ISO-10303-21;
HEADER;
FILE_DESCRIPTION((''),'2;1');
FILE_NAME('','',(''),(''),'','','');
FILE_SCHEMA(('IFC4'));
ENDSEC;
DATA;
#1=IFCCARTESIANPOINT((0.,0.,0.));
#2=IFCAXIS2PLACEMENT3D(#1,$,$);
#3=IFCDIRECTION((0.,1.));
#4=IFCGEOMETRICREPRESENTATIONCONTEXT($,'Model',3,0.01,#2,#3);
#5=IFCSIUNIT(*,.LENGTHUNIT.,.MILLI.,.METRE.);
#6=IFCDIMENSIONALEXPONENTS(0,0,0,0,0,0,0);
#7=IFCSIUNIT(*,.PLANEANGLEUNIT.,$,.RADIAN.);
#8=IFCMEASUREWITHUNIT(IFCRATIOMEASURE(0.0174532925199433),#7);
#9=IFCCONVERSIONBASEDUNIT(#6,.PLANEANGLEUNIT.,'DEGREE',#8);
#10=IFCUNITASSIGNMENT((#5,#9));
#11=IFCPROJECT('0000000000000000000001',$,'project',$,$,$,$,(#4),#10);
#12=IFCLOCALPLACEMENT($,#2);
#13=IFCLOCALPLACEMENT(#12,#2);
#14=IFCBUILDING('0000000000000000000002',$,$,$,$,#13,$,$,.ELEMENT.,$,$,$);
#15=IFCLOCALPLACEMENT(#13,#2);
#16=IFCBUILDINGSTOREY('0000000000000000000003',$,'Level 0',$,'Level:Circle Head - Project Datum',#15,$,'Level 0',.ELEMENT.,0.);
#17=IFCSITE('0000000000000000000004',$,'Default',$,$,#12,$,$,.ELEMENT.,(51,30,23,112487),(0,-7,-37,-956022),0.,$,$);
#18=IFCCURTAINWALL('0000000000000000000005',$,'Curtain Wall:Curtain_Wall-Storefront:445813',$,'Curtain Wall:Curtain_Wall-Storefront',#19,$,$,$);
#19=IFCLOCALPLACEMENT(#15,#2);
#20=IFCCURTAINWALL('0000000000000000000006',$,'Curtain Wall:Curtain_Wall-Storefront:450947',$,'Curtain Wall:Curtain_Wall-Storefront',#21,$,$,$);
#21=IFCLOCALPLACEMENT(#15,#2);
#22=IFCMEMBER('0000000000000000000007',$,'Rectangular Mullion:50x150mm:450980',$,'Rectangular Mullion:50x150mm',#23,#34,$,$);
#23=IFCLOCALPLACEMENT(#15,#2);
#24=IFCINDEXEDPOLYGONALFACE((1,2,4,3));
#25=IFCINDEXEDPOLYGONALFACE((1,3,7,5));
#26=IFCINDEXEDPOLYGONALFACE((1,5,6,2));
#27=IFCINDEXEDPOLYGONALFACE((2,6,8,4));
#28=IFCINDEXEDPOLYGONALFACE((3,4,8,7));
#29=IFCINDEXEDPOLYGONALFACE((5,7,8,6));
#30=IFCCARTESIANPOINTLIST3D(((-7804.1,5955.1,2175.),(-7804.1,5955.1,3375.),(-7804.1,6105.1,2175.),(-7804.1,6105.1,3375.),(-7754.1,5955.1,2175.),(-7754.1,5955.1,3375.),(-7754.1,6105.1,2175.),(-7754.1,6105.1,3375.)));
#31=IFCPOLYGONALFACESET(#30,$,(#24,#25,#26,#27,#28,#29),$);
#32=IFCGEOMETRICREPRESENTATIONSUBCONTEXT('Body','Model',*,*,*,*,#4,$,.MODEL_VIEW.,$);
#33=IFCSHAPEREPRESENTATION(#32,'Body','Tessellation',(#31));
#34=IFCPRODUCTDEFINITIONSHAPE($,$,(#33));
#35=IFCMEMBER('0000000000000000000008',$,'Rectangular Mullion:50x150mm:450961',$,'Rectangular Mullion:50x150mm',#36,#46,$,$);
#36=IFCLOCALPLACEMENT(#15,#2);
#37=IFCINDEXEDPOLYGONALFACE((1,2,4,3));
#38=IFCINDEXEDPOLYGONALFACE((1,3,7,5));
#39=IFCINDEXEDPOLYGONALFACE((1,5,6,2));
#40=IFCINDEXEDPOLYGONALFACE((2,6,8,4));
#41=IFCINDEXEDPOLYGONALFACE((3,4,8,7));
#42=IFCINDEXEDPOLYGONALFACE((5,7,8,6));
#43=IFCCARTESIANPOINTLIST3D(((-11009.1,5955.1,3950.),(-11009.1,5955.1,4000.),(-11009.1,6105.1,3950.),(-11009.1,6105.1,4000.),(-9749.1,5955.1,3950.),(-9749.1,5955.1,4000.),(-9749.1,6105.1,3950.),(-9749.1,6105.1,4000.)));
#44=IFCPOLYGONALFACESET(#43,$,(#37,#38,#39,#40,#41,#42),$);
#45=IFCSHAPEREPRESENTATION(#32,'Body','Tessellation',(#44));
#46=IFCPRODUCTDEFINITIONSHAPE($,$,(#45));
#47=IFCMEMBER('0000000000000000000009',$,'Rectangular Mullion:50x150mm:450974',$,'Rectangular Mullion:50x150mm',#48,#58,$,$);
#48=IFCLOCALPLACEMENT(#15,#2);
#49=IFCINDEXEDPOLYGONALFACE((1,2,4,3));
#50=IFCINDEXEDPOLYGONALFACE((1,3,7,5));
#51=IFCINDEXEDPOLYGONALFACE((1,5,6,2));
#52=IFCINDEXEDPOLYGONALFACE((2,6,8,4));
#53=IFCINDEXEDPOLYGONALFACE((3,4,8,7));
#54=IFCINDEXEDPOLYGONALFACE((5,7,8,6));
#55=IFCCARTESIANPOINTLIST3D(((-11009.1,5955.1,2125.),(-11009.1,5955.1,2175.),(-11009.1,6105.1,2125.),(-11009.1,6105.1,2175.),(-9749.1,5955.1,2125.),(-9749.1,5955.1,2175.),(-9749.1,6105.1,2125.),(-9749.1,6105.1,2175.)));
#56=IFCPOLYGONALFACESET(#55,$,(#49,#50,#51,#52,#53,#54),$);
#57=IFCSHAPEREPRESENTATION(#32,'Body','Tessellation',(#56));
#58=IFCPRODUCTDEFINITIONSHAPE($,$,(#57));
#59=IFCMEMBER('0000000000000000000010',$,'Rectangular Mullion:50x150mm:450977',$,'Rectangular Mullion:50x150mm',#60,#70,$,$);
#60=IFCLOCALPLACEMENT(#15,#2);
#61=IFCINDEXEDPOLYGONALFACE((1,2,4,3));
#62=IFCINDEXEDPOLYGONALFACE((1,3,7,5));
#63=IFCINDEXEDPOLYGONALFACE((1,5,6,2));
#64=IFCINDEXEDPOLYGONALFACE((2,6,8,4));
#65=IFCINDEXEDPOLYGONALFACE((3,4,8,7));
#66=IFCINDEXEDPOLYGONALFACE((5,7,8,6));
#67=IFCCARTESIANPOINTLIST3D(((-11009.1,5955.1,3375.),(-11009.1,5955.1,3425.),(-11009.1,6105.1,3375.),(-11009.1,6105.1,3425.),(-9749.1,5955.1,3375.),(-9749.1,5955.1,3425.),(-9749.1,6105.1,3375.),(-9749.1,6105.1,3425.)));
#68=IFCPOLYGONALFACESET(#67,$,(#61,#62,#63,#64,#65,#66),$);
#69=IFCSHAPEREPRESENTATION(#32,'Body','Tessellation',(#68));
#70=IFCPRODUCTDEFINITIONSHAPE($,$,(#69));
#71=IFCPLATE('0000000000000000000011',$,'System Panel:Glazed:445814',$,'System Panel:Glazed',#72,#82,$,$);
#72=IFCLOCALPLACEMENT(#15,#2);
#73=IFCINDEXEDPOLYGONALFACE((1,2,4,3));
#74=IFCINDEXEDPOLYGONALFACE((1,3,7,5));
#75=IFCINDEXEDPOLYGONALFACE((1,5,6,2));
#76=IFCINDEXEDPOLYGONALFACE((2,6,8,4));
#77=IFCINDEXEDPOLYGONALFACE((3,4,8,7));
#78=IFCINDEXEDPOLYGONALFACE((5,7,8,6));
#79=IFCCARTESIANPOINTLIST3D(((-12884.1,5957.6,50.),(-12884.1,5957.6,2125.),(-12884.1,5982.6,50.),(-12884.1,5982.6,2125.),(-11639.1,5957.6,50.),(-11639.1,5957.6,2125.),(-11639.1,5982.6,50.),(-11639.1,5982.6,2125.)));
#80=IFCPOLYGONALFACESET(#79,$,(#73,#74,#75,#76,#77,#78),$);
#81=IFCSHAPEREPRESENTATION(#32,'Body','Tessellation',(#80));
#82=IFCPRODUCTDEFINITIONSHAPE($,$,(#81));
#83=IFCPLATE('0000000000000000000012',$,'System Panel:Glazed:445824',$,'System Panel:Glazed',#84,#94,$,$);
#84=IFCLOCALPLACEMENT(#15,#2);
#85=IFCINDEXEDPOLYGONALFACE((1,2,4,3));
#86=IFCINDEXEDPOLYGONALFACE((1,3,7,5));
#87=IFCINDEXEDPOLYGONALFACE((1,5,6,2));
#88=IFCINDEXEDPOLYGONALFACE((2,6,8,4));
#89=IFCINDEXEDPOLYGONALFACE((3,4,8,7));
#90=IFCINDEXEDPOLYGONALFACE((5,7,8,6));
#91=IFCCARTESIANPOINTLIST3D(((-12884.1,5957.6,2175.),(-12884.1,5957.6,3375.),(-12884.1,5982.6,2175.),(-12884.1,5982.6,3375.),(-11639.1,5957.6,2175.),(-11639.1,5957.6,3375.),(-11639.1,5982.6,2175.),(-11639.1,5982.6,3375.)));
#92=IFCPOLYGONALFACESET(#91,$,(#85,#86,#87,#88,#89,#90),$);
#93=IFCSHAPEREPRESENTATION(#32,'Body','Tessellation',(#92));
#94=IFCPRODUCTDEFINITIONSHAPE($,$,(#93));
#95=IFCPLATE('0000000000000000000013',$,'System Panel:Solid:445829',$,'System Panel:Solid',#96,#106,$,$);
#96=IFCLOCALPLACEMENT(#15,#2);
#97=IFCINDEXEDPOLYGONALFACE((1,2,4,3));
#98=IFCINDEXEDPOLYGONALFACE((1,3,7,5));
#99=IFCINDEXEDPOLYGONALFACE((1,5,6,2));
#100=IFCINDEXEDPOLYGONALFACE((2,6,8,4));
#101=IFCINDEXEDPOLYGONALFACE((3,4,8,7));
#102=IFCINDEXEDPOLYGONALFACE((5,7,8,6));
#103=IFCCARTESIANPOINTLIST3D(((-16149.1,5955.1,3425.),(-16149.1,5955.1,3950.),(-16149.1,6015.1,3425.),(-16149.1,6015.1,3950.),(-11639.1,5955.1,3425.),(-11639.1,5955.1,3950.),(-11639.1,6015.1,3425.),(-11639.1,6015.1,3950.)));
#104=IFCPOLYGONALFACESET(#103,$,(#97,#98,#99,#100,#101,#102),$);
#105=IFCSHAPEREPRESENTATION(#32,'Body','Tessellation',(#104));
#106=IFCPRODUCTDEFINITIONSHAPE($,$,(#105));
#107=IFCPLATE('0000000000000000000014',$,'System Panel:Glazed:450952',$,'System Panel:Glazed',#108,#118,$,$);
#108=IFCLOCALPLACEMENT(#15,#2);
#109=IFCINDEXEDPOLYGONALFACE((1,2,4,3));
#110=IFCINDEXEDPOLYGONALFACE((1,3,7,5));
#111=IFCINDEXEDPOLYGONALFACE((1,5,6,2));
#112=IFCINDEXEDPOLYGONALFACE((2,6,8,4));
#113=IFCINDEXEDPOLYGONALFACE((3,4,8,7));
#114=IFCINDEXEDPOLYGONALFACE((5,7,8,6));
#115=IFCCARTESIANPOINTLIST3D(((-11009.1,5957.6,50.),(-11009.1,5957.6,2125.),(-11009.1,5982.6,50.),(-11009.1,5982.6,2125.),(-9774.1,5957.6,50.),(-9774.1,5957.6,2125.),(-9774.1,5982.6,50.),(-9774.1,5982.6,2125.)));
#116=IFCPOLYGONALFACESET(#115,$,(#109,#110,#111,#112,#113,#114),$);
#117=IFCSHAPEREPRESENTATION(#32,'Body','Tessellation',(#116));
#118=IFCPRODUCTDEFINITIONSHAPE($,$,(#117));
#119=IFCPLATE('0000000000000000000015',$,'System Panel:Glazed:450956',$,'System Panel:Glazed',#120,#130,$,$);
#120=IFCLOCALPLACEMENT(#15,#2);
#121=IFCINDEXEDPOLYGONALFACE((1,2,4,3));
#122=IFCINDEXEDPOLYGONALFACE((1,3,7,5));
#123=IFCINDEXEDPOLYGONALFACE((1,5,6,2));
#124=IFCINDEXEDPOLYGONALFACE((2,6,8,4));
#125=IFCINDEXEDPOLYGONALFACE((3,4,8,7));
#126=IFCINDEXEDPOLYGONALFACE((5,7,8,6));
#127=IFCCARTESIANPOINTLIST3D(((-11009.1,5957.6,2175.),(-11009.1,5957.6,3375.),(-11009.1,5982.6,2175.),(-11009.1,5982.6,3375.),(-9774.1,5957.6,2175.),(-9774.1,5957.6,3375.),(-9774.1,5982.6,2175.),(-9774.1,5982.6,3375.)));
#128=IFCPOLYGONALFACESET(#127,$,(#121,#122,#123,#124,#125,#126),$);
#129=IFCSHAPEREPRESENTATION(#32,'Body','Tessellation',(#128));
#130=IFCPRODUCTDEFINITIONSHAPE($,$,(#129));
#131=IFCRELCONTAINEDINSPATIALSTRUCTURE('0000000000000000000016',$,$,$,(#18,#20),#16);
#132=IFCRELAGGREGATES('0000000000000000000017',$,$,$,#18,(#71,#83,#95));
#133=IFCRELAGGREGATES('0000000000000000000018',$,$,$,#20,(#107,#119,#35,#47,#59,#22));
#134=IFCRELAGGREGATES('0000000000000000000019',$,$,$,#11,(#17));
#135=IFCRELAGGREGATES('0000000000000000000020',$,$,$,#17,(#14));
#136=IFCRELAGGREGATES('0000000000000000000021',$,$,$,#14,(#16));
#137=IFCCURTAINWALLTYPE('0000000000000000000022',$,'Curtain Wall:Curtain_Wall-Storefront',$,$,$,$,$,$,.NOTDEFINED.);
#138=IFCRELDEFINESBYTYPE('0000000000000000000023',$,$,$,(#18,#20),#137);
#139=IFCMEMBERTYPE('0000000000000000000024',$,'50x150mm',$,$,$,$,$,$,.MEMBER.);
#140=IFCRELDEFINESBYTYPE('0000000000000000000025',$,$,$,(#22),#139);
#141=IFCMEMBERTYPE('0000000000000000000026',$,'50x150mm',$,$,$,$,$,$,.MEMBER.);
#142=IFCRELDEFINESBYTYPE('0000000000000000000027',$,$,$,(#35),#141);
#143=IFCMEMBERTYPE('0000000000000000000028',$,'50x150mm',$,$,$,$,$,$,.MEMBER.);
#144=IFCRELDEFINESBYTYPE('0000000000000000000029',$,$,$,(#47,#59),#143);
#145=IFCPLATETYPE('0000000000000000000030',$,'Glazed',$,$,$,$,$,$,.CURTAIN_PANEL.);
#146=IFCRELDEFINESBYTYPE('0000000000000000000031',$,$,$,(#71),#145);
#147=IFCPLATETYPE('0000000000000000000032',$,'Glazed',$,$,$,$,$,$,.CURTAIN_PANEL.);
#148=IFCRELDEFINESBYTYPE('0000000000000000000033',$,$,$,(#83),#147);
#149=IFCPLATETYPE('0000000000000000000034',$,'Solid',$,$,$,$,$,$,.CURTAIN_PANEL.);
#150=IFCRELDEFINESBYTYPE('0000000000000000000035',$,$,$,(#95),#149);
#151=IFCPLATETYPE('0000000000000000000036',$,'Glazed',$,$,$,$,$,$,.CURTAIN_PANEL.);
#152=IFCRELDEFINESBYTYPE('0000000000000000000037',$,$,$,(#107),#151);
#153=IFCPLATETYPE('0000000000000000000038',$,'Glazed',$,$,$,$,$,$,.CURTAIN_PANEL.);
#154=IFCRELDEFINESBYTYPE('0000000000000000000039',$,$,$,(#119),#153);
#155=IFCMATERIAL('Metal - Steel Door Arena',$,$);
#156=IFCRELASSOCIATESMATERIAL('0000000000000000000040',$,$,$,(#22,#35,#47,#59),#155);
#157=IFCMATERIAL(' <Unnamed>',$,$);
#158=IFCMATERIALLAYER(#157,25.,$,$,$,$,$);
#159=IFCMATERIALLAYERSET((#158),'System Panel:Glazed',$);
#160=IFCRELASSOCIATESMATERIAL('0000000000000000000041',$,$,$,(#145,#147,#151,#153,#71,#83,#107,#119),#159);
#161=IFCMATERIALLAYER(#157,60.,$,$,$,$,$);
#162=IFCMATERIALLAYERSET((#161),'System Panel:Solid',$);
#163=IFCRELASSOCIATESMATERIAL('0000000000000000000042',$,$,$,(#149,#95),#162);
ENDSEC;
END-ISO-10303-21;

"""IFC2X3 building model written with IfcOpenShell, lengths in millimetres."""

from ifc_helpers import new_model, entity, si_unit, converted_unit, direction, frame, frame_2d, origin, origin_2d_with_axis, place, context, subcontext, project, spatial, rectangle, extrude, source, transform, mapped, material, layer, layer_set, layer_usage, type_object, type_shapes, element, aggregate, save


model = new_model("IFC2X3")

# Units and contexts
model_context = context("Model", 3, precision=0.01, world=origin(), true_north=direction((0.0, 1.0)))
body_context = subcontext(model_context, "Body", "Model", "MODEL_VIEW")
ifc_project = project(units=[si_unit("LENGTHUNIT", "METRE", prefix="MILLI"), converted_unit("PLANEANGLEUNIT", "DEGREE", entity("IfcRatioMeasure", 0.0174532925199433), si_unit("PLANEANGLEUNIT", "RADIAN"), dimensions=[0, 0, 0, 0, 0, 0, 0])], contexts=[model_context])

# Site, building, storey
site_placement = place(None, origin())
site = spatial("IfcSite", under=ifc_project, at=site_placement, Name="Default", CompositionType="ELEMENT", RefLatitude=(51, 30, 23, 112487), RefLongitude=(0, -7, -37, -956022), RefElevation=0.0)
building_placement = place(site_placement, origin())
building = spatial("IfcBuilding", under=site, at=building_placement, CompositionType="ELEMENT")
storey_placement = place(building_placement, origin())
storey = spatial("IfcBuildingStorey", under=building, at=storey_placement, Name="Level 0", ObjectType="Level:Circle Head - Project Datum", LongName="Level 0", CompositionType="ELEMENT", Elevation=0.0)

# Curtain walls
curtain_wall_type = type_object("IfcCurtainWallType", Name="Curtain Wall:Curtain_Wall-Storefront", PredefinedType="NOTDEFINED")
curtain_wall_1_placement = place(storey_placement, origin())
curtain_wall_1 = element("IfcCurtainWall", 1, at=curtain_wall_1_placement, inside=storey, type_object=curtain_wall_type, Name="Curtain Wall:Curtain_Wall-Storefront:445813", ObjectType="Curtain Wall:Curtain_Wall-Storefront")
ifc_material_1 = material(Name="Metal - Steel Door Arena")
curtain_wall_2_placement = place(storey_placement, origin())
curtain_wall_2 = element("IfcCurtainWall", 2, at=curtain_wall_2_placement, inside=storey, type_object=curtain_wall_type, Name="Curtain Wall:Curtain_Wall-Storefront:450947", ObjectType="Curtain Wall:Curtain_Wall-Storefront")

# Members
member_type_1 = type_object("IfcMemberType", Name="50x150mm", PredefinedType="MEMBER")
shared_shape_1 = source(origin(), body_context, "Body", "SweptSolid", [
    extrude(rectangle(XDim=150.0, YDim=50.0, at=origin_2d_with_axis()), frame((0.0, 0.0, -1200.0), z_axis=(0.0, 0.0, 1.0), x_axis=(0.0, -1.0, 0.0)), (0.0, 0.0, 1.0), 1200.0),
])
type_shapes(member_type_1, [shared_shape_1])
member_1_placement = place(storey_placement, frame((-7779.1, 6030.1, 2175.0), z_axis=(0.0, 0.0, -1.0), x_axis=(-1.0, 0.0, 0.0)))
member_1 = element("IfcMember", 3, at=member_1_placement, type_object=member_type_1, material=ifc_material_1, Name="Rectangular Mullion:50x150mm:450980", ObjectType="Rectangular Mullion:50x150mm", context=body_context, shape_type="MappedRepresentation", body=[
    mapped(shared_shape_1, transform((0.0, 0.0, 0.0), scale=1.0)),
])
member_type_2 = type_object("IfcMemberType", Name="50x150mm", PredefinedType="MEMBER")
shared_shape_2 = source(origin(), body_context, "Body", "SweptSolid", [
    extrude(rectangle(XDim=150.0, YDim=50.0, at=origin_2d_with_axis()), frame((-25.0, 0.0, -1260.0), z_axis=(0.0, 0.0, 1.0), x_axis=(0.0, -1.0, 0.0)), (0.0, 0.0, 1.0), 1260.0),
])
type_shapes(member_type_2, [shared_shape_2])
member_2_placement = place(storey_placement, frame((-11009.1, 6030.1, 4000.0), z_axis=(-1.0, 0.0, 0.0), x_axis=(0.0, 0.0, 1.0)))
member_2 = element("IfcMember", 4, at=member_2_placement, type_object=member_type_2, material=ifc_material_1, Name="Rectangular Mullion:50x150mm:450961", ObjectType="Rectangular Mullion:50x150mm", context=body_context, shape_type="MappedRepresentation", body=[
    mapped(shared_shape_2, transform((0.0, 0.0, 0.0), scale=1.0)),
])
member_type_3 = type_object("IfcMemberType", Name="50x150mm", PredefinedType="MEMBER")
shared_shape_3 = source(origin(), body_context, "Body", "SweptSolid", [
    extrude(rectangle(XDim=150.0, YDim=50.0, at=origin_2d_with_axis()), frame((0.0, 0.0, -1260.0), z_axis=(0.0, 0.0, 1.0), x_axis=(0.0, -1.0, 0.0)), (0.0, 0.0, 1.0), 1260.0),
])
type_shapes(member_type_3, [shared_shape_3])
member_3_placement = place(storey_placement, frame((-11009.1, 6030.1, 2150.0), z_axis=(-1.0, 0.0, 0.0), x_axis=(0.0, 0.0, 1.0)))
member_3 = element("IfcMember", 5, at=member_3_placement, type_object=member_type_3, material=ifc_material_1, Name="Rectangular Mullion:50x150mm:450974", ObjectType="Rectangular Mullion:50x150mm", context=body_context, shape_type="MappedRepresentation", body=[
    mapped(shared_shape_3, transform((0.0, 0.0, 0.0), scale=1.0)),
])
member_4_placement = place(storey_placement, frame((-11009.1, 6030.1, 3400.0), z_axis=(-1.0, 0.0, 0.0), x_axis=(0.0, 0.0, 1.0)))
member_4 = element("IfcMember", 6, at=member_4_placement, type_object=member_type_3, material=ifc_material_1, Name="Rectangular Mullion:50x150mm:450977", ObjectType="Rectangular Mullion:50x150mm", context=body_context, shape_type="MappedRepresentation", body=[
    mapped(shared_shape_3, transform((0.0, 0.0, 0.0), scale=1.0)),
])

# Plates
ifc_material_2 = material(Name=" <Unnamed>")
ifc_layer_1 = layer(ifc_material_2, 25.0)
ifc_layer_set_1 = layer_set([ifc_layer_1], Name="System Panel:Glazed")
ifc_layer_usage_1 = layer_usage(ifc_layer_set_1, "AXIS3", "POSITIVE", 0.2)
plate_type_1 = type_object("IfcPlateType", Name="Glazed", PredefinedType="CURTAIN_PANEL", material=ifc_layer_set_1)
shared_shape_4 = source(origin(), body_context, "Body", "SweptSolid", [
    extrude(rectangle(XDim=25.0, YDim=1245.0, at=origin_2d_with_axis()), frame((0.0, 60.0, 0.0), z_axis=(0.0, 0.0, 1.0), x_axis=(0.0, 1.0, 0.0)), (0.0, 0.0, 1.0), 2075.0),
])
type_shapes(plate_type_1, [shared_shape_4])
plate_1_placement = place(curtain_wall_1_placement, frame((-12261.6, 6030.1, 50.0), z_axis=(0.0, 0.0, 1.0), x_axis=(-1.0, 0.0, 0.0)))
plate_1 = element("IfcPlate", 7, at=plate_1_placement, type_object=plate_type_1, material=ifc_layer_usage_1, Name="System Panel:Glazed:445814", ObjectType="System Panel:Glazed", context=body_context, shape_type="MappedRepresentation", body=[
    mapped(shared_shape_4, transform((0.0, 0.0, 0.0), scale=1.0)),
])
ifc_layer_usage_2 = layer_usage(ifc_layer_set_1, "AXIS3", "POSITIVE", 0.2)
plate_type_2 = type_object("IfcPlateType", Name="Glazed", PredefinedType="CURTAIN_PANEL", material=ifc_layer_set_1)
shared_shape_5 = source(origin(), body_context, "Body", "SweptSolid", [
    extrude(rectangle(XDim=25.0, YDim=1245.0, at=origin_2d_with_axis()), frame((0.0, 60.0, 0.0), z_axis=(0.0, 0.0, 1.0), x_axis=(0.0, 1.0, 0.0)), (0.0, 0.0, 1.0), 1200.0),
])
type_shapes(plate_type_2, [shared_shape_5])
plate_2_placement = place(curtain_wall_1_placement, frame((-12261.6, 6030.1, 2175.0), z_axis=(0.0, 0.0, 1.0), x_axis=(-1.0, 0.0, 0.0)))
plate_2 = element("IfcPlate", 8, at=plate_2_placement, type_object=plate_type_2, material=ifc_layer_usage_2, Name="System Panel:Glazed:445824", ObjectType="System Panel:Glazed", context=body_context, shape_type="MappedRepresentation", body=[
    mapped(shared_shape_5, transform((0.0, 0.0, 0.0), scale=1.0)),
])
ifc_layer_2 = layer(ifc_material_2, 60.0)
ifc_layer_set_2 = layer_set([ifc_layer_2], Name="System Panel:Solid")
ifc_layer_usage_3 = layer_usage(ifc_layer_set_2, "AXIS3", "POSITIVE", 0.1)
plate_type_3 = type_object("IfcPlateType", Name="Solid", PredefinedType="CURTAIN_PANEL", material=ifc_layer_set_2)
shared_shape_6 = source(origin(), body_context, "Body", "SweptSolid", [
    extrude(rectangle(XDim=525.0, YDim=4510.0, at=frame_2d((0.0, 0.0), x_axis=(1.0, 0.0))), frame((0.0, 15.0, 262.5), z_axis=(0.0, 1.0, 0.0), x_axis=(0.0, 0.0, 1.0)), (0.0, 0.0, 1.0), 60.0),
])
type_shapes(plate_type_3, [shared_shape_6])
plate_3_placement = place(curtain_wall_1_placement, frame((-13894.1, 6030.1, 3425.0), z_axis=(0.0, 0.0, 1.0), x_axis=(-1.0, 0.0, 0.0)))
plate_3 = element("IfcPlate", 9, at=plate_3_placement, type_object=plate_type_3, material=ifc_layer_usage_3, Name="System Panel:Solid:445829", ObjectType="System Panel:Solid", context=body_context, shape_type="MappedRepresentation", body=[
    mapped(shared_shape_6, transform((0.0, 0.0, 0.0), scale=1.0)),
])
aggregate(curtain_wall_1, [plate_1, plate_2, plate_3])
ifc_layer_usage_4 = layer_usage(ifc_layer_set_1, "AXIS3", "POSITIVE", 0.2)
plate_type_4 = type_object("IfcPlateType", Name="Glazed", PredefinedType="CURTAIN_PANEL", material=ifc_layer_set_1)
shared_shape_7 = source(origin(), body_context, "Body", "SweptSolid", [
    extrude(rectangle(XDim=25.0, YDim=1235.0, at=origin_2d_with_axis()), frame((0.0, 60.0, 0.0), z_axis=(0.0, 0.0, 1.0), x_axis=(0.0, 1.0, 0.0)), (0.0, 0.0, 1.0), 2075.0),
])
type_shapes(plate_type_4, [shared_shape_7])
plate_4_placement = place(curtain_wall_2_placement, frame((-10391.6, 6030.1, 50.0), z_axis=(0.0, 0.0, 1.0), x_axis=(-1.0, 0.0, 0.0)))
plate_4 = element("IfcPlate", 10, at=plate_4_placement, type_object=plate_type_4, material=ifc_layer_usage_4, Name="System Panel:Glazed:450952", ObjectType="System Panel:Glazed", context=body_context, shape_type="MappedRepresentation", body=[
    mapped(shared_shape_7, transform((0.0, 0.0, 0.0), scale=1.0)),
])
ifc_layer_usage_5 = layer_usage(ifc_layer_set_1, "AXIS3", "POSITIVE", 0.2)
plate_type_5 = type_object("IfcPlateType", Name="Glazed", PredefinedType="CURTAIN_PANEL", material=ifc_layer_set_1)
shared_shape_8 = source(origin(), body_context, "Body", "SweptSolid", [
    extrude(rectangle(XDim=25.0, YDim=1235.0, at=origin_2d_with_axis()), frame((0.0, 60.0, 0.0), z_axis=(0.0, 0.0, 1.0), x_axis=(0.0, 1.0, 0.0)), (0.0, 0.0, 1.0), 1200.0),
])
type_shapes(plate_type_5, [shared_shape_8])
plate_5_placement = place(curtain_wall_2_placement, frame((-10391.6, 6030.1, 2175.0), z_axis=(0.0, 0.0, 1.0), x_axis=(-1.0, 0.0, 0.0)))
plate_5 = element("IfcPlate", 11, at=plate_5_placement, type_object=plate_type_5, material=ifc_layer_usage_5, Name="System Panel:Glazed:450956", ObjectType="System Panel:Glazed", context=body_context, shape_type="MappedRepresentation", body=[
    mapped(shared_shape_8, transform((0.0, 0.0, 0.0), scale=1.0)),
])
aggregate(curtain_wall_2, [plate_4, plate_5, member_2, member_3, member_4, member_1])

save(model, "model.ifc")
